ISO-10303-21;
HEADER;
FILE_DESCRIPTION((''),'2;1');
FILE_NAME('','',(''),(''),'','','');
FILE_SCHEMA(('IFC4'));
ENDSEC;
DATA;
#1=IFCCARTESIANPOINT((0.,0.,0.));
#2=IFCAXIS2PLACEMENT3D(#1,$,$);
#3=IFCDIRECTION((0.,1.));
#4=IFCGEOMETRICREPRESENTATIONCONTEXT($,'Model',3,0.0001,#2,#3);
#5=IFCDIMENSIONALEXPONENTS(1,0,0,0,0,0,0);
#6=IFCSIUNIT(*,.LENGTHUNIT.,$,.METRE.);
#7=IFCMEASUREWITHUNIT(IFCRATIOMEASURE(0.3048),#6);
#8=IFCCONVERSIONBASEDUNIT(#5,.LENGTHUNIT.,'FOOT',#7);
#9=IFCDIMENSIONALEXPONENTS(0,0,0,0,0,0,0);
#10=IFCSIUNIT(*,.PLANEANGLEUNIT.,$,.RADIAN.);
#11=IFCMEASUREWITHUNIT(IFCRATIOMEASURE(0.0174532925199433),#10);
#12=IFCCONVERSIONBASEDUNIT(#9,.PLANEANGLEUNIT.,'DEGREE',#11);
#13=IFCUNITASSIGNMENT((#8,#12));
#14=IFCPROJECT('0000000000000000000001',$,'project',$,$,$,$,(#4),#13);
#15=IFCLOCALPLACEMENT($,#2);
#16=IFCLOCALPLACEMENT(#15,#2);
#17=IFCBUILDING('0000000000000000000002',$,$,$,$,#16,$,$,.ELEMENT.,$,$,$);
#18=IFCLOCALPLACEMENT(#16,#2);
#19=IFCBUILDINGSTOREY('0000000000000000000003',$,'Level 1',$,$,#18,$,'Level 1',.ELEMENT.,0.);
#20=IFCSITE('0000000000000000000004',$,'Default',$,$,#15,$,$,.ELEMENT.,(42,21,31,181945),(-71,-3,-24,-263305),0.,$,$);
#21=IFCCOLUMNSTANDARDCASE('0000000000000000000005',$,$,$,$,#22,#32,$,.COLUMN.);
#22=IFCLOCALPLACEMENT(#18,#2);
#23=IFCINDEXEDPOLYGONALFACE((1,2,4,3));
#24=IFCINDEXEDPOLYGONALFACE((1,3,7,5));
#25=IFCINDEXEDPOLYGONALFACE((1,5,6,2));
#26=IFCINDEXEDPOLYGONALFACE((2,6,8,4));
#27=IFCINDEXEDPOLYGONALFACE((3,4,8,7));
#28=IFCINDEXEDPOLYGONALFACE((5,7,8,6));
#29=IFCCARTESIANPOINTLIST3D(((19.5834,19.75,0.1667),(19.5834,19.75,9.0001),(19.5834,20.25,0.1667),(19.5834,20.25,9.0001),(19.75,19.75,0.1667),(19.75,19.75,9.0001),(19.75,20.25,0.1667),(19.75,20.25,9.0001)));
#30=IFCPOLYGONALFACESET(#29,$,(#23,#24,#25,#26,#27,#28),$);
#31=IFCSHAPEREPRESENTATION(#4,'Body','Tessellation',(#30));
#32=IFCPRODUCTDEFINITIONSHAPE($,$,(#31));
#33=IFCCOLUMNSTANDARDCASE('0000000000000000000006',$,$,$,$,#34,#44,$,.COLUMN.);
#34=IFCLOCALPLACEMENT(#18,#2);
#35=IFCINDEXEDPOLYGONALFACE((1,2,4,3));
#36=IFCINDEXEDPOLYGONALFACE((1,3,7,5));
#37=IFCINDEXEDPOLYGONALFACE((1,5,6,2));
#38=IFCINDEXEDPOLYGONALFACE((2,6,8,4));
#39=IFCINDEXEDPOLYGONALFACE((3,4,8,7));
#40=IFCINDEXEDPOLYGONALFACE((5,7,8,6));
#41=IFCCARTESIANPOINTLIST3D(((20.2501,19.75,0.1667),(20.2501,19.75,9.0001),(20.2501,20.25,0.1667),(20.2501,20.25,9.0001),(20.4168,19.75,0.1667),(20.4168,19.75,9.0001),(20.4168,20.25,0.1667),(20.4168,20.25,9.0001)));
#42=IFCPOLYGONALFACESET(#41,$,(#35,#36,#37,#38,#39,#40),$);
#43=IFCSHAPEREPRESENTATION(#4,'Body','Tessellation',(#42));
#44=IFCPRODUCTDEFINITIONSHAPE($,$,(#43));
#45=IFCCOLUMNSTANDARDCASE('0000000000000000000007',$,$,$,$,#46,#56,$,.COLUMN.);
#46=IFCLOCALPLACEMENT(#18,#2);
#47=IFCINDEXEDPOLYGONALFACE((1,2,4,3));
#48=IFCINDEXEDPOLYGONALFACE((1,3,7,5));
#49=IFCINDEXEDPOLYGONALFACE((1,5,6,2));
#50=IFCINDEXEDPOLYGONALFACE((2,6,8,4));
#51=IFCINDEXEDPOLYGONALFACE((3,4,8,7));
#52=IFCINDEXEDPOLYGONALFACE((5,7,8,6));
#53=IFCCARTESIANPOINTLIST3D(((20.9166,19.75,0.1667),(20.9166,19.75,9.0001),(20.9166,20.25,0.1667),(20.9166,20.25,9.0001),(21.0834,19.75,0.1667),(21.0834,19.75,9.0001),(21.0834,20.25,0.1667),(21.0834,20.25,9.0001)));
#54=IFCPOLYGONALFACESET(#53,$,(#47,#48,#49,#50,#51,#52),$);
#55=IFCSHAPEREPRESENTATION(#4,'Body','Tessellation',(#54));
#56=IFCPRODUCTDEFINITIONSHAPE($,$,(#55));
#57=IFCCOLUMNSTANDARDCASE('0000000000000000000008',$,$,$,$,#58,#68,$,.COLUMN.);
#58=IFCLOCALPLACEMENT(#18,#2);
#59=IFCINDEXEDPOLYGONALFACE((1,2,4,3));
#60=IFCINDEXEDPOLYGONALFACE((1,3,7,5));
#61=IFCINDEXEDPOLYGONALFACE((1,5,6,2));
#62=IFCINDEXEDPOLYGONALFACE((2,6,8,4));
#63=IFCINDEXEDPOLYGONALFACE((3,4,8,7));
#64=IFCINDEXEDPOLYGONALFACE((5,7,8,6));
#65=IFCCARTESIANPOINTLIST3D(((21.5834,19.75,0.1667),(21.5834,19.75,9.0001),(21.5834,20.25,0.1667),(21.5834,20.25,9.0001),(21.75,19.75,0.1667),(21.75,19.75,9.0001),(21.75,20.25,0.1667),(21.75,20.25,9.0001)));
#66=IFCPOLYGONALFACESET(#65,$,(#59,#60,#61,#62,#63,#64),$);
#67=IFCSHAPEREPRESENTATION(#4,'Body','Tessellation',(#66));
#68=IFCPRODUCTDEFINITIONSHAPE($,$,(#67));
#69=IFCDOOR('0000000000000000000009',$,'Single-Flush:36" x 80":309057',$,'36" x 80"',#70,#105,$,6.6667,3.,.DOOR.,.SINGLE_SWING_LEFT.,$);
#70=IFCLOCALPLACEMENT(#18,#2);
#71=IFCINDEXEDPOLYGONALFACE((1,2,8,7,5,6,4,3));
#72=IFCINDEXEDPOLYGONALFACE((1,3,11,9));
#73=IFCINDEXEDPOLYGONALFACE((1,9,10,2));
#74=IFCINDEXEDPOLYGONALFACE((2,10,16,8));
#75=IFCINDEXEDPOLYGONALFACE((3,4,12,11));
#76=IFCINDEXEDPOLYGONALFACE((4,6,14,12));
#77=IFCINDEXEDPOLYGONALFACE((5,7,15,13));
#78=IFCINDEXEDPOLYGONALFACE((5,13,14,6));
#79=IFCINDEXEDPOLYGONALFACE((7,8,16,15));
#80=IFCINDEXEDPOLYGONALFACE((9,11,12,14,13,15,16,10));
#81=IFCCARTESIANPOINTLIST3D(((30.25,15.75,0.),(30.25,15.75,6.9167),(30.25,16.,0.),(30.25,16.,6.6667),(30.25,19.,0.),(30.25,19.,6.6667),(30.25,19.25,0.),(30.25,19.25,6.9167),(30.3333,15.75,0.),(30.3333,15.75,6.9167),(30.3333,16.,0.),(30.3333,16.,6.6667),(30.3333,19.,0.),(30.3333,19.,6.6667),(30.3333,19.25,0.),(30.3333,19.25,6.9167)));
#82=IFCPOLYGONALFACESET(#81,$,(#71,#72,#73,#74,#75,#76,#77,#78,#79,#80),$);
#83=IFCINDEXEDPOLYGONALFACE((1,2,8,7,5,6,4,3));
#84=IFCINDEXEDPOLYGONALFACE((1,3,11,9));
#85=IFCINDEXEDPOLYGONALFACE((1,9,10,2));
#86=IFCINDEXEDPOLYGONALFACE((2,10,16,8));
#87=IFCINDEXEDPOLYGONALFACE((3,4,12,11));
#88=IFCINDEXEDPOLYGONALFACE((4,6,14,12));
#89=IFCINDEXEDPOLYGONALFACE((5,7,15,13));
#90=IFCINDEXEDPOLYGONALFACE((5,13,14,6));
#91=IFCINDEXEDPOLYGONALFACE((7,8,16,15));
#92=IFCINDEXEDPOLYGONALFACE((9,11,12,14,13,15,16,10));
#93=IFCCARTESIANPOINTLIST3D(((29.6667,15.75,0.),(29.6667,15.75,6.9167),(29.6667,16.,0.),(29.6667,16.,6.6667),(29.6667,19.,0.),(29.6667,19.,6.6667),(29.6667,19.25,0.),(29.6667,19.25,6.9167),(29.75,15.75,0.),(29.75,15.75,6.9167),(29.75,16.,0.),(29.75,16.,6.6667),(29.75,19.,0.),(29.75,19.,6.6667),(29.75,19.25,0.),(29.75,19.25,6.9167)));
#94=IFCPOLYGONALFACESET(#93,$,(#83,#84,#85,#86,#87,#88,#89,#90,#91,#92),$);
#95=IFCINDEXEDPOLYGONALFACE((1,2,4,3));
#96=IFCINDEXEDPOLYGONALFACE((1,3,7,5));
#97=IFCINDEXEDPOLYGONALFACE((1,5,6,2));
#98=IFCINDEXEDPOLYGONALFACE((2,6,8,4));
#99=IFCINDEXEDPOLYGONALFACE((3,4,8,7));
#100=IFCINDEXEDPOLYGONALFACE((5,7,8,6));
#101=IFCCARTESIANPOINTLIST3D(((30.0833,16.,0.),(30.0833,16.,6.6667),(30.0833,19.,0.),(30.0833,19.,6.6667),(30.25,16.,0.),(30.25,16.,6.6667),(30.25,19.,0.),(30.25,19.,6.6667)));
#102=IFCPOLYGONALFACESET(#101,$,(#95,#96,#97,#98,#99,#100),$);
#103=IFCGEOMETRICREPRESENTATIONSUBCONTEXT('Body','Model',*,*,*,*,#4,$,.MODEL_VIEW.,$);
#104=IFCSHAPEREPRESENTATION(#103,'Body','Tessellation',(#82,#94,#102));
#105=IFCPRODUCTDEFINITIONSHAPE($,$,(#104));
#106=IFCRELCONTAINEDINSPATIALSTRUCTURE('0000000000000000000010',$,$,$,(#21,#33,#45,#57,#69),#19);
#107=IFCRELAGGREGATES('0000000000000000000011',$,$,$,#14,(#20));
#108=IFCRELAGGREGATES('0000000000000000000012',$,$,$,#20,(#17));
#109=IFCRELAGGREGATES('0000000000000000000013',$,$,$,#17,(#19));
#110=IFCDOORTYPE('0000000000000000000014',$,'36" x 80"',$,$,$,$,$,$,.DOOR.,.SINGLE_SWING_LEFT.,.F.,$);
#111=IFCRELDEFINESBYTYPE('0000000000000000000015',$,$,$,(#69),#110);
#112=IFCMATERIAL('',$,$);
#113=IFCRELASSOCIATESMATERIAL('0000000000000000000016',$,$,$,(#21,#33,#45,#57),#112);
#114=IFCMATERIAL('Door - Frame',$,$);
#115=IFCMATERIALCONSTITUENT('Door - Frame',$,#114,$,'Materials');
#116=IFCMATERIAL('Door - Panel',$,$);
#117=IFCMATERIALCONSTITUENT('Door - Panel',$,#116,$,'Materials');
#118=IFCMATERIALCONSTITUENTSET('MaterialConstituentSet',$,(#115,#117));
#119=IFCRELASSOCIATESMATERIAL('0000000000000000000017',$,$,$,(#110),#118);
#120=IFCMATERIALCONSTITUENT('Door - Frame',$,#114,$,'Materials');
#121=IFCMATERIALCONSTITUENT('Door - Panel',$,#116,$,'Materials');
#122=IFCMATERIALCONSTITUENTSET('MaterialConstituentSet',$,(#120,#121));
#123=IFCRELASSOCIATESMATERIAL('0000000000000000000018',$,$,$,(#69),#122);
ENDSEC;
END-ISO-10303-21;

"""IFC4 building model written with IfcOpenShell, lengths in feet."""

from ifc_helpers import new_model, entity, si_unit, converted_unit, direction, frame, origin, origin_2d_with_axis, place, context, subcontext, project, spatial, polyline, rectangle, outline, extrude, source, transform, mapped, material, constituent, constituent_set, type_object, type_shapes, element, save


model = new_model("IFC4")

# Units and contexts
model_context = context("Model", 3, precision=0.0001, world=origin(), true_north=direction((0.0, 1.0)))
body_context = subcontext(model_context, "Body", "Model", "MODEL_VIEW")
ifc_project = project(units=[converted_unit("LENGTHUNIT", "FOOT", entity("IfcRatioMeasure", 0.3048), si_unit("LENGTHUNIT", "METRE"), dimensions=[1, 0, 0, 0, 0, 0, 0]), converted_unit("PLANEANGLEUNIT", "DEGREE", entity("IfcRatioMeasure", 0.0174532925199433), si_unit("PLANEANGLEUNIT", "RADIAN"), dimensions=[0, 0, 0, 0, 0, 0, 0])], contexts=[model_context])

# Site, building, storey
site_placement = place(None, origin())
site = spatial("IfcSite", under=ifc_project, at=site_placement, Name="Default", CompositionType="ELEMENT", RefLatitude=(42, 21, 31, 181945), RefLongitude=(-71, -3, -24, -263305), RefElevation=0.0)
building_placement = place(site_placement, origin())
building = spatial("IfcBuilding", under=site, at=building_placement, CompositionType="ELEMENT")
storey_placement = place(building_placement, origin())
storey = spatial("IfcBuildingStorey", under=building, at=storey_placement, Name="Level 1", LongName="Level 1", CompositionType="ELEMENT", Elevation=0.0)

# Columns
ifc_material_1 = material(Name="")
placement_1 = place(storey_placement, frame((0.25, 20.0, 0.0)))
for number, where, z_axis, x_axis in (
    (1, (19.4167, 0.0, 0.1667), (0.0, 0.0, 1.0), (1.0, 0.0, 0.0)),
    (2, (20.0834, 0.0, 0.1667), (0.0, 0.0, 1.0), (1.0, 0.0, 0.0)),
    (3, (20.75, 0.0, 0.1667), (0.0, 0.0, 1.0), (1.0, 0.0, 0.0)),
    (4, (21.4167, 0.0, 0.1667), (0.0, 0.0, 1.0), (1.0, 0.0, 0.0)),
):
    element("IfcColumnStandardCase", number, at=place(placement_1, frame(where, z_axis=z_axis, x_axis=x_axis)), inside=storey, material=ifc_material_1, PredefinedType="COLUMN", context=model_context, shape_type="SweptSolid", body=[
        extrude(rectangle(XDim=0.1667, YDim=0.5), origin(), (0.0, 0.0, 1.0), 8.8334),
    ])
placement_2 = place(storey_placement, frame((30.0, 45.75, 0.0), z_axis=(0.0, 0.0, 1.0), x_axis=(0.0, -1.0, 0.0)))

# Door
ifc_material_2 = material(Name="Door - Frame")
ifc_constituent_1 = constituent(ifc_material_2, Name="Door - Frame", Category="Materials")
ifc_material_3 = material(Name="Door - Panel")
ifc_constituent_2 = constituent(ifc_material_3, Name="Door - Panel", Category="Materials")
ifc_constituent_set_1 = constituent_set(constituents=[ifc_constituent_1, ifc_constituent_2], Name="MaterialConstituentSet")
ifc_constituent_3 = constituent(ifc_material_2, Name="Door - Frame", Category="Materials")
ifc_constituent_4 = constituent(ifc_material_3, Name="Door - Panel", Category="Materials")
ifc_constituent_set_2 = constituent_set(constituents=[ifc_constituent_3, ifc_constituent_4], Name="MaterialConstituentSet")
door_type = type_object("IfcDoorType", Name="36\" x 80\"", OperationType="SINGLE_SWING_LEFT", ParameterTakesPrecedence=False, PredefinedType="DOOR", material=ifc_constituent_set_2)
shared_shape = source(origin(), body_context, "Body", "SweptSolid", [
    extrude(outline(polyline([(-1.75, -3.5208), (1.75, -3.5208), (1.75, 3.3958), (1.5, 3.3958), (1.5, -3.2708), (-1.5, -3.2708), (-1.5, 3.3958), (-1.75, 3.3958), (-1.75, -3.5208)])), frame((1.5, 0.5833, 3.3958), z_axis=(0.0, -1.0, 0.0), x_axis=(-1.0, 0.0, 0.0)), (0.0, 0.0, 1.0), 0.0833),
    extrude(outline(polyline([(-3.5208, -1.75), (3.3958, -1.75), (3.3958, -1.5), (-3.2708, -1.5), (-3.2708, 1.5), (3.3958, 1.5), (3.3958, 1.75), (-3.5208, 1.75), (-3.5208, -1.75)])), frame((1.5, 0.0, 3.3958), z_axis=(0.0, -1.0, 0.0), x_axis=(0.0, 0.0, -1.0)), (0.0, 0.0, 1.0), 0.0833),
    extrude(rectangle(XDim=3.0, YDim=0.1667, at=origin_2d_with_axis()), frame((1.5, 0.4167, 0.0)), (0.0, 0.0, 1.0), 6.6667),
])
type_shapes(door_type, [shared_shape])
placement_3 = place(placement_2, frame((26.75, -0.25, 0.0)))
door_placement = place(placement_3, origin())
element("IfcDoor", 5, at=door_placement, inside=storey, type_object=door_type, material=ifc_constituent_set_1, Name="Single-Flush:36\" x 80\":309057", ObjectType="36\" x 80\"", OperationType="SINGLE_SWING_LEFT", OverallHeight=6.6667, OverallWidth=3.0, PredefinedType="DOOR", context=body_context, shape_type="MappedRepresentation", body=[
    mapped(shared_shape, transform((0.0, 0.0, 0.0), scale=1.0)),
])

save(model, "model.ifc")
